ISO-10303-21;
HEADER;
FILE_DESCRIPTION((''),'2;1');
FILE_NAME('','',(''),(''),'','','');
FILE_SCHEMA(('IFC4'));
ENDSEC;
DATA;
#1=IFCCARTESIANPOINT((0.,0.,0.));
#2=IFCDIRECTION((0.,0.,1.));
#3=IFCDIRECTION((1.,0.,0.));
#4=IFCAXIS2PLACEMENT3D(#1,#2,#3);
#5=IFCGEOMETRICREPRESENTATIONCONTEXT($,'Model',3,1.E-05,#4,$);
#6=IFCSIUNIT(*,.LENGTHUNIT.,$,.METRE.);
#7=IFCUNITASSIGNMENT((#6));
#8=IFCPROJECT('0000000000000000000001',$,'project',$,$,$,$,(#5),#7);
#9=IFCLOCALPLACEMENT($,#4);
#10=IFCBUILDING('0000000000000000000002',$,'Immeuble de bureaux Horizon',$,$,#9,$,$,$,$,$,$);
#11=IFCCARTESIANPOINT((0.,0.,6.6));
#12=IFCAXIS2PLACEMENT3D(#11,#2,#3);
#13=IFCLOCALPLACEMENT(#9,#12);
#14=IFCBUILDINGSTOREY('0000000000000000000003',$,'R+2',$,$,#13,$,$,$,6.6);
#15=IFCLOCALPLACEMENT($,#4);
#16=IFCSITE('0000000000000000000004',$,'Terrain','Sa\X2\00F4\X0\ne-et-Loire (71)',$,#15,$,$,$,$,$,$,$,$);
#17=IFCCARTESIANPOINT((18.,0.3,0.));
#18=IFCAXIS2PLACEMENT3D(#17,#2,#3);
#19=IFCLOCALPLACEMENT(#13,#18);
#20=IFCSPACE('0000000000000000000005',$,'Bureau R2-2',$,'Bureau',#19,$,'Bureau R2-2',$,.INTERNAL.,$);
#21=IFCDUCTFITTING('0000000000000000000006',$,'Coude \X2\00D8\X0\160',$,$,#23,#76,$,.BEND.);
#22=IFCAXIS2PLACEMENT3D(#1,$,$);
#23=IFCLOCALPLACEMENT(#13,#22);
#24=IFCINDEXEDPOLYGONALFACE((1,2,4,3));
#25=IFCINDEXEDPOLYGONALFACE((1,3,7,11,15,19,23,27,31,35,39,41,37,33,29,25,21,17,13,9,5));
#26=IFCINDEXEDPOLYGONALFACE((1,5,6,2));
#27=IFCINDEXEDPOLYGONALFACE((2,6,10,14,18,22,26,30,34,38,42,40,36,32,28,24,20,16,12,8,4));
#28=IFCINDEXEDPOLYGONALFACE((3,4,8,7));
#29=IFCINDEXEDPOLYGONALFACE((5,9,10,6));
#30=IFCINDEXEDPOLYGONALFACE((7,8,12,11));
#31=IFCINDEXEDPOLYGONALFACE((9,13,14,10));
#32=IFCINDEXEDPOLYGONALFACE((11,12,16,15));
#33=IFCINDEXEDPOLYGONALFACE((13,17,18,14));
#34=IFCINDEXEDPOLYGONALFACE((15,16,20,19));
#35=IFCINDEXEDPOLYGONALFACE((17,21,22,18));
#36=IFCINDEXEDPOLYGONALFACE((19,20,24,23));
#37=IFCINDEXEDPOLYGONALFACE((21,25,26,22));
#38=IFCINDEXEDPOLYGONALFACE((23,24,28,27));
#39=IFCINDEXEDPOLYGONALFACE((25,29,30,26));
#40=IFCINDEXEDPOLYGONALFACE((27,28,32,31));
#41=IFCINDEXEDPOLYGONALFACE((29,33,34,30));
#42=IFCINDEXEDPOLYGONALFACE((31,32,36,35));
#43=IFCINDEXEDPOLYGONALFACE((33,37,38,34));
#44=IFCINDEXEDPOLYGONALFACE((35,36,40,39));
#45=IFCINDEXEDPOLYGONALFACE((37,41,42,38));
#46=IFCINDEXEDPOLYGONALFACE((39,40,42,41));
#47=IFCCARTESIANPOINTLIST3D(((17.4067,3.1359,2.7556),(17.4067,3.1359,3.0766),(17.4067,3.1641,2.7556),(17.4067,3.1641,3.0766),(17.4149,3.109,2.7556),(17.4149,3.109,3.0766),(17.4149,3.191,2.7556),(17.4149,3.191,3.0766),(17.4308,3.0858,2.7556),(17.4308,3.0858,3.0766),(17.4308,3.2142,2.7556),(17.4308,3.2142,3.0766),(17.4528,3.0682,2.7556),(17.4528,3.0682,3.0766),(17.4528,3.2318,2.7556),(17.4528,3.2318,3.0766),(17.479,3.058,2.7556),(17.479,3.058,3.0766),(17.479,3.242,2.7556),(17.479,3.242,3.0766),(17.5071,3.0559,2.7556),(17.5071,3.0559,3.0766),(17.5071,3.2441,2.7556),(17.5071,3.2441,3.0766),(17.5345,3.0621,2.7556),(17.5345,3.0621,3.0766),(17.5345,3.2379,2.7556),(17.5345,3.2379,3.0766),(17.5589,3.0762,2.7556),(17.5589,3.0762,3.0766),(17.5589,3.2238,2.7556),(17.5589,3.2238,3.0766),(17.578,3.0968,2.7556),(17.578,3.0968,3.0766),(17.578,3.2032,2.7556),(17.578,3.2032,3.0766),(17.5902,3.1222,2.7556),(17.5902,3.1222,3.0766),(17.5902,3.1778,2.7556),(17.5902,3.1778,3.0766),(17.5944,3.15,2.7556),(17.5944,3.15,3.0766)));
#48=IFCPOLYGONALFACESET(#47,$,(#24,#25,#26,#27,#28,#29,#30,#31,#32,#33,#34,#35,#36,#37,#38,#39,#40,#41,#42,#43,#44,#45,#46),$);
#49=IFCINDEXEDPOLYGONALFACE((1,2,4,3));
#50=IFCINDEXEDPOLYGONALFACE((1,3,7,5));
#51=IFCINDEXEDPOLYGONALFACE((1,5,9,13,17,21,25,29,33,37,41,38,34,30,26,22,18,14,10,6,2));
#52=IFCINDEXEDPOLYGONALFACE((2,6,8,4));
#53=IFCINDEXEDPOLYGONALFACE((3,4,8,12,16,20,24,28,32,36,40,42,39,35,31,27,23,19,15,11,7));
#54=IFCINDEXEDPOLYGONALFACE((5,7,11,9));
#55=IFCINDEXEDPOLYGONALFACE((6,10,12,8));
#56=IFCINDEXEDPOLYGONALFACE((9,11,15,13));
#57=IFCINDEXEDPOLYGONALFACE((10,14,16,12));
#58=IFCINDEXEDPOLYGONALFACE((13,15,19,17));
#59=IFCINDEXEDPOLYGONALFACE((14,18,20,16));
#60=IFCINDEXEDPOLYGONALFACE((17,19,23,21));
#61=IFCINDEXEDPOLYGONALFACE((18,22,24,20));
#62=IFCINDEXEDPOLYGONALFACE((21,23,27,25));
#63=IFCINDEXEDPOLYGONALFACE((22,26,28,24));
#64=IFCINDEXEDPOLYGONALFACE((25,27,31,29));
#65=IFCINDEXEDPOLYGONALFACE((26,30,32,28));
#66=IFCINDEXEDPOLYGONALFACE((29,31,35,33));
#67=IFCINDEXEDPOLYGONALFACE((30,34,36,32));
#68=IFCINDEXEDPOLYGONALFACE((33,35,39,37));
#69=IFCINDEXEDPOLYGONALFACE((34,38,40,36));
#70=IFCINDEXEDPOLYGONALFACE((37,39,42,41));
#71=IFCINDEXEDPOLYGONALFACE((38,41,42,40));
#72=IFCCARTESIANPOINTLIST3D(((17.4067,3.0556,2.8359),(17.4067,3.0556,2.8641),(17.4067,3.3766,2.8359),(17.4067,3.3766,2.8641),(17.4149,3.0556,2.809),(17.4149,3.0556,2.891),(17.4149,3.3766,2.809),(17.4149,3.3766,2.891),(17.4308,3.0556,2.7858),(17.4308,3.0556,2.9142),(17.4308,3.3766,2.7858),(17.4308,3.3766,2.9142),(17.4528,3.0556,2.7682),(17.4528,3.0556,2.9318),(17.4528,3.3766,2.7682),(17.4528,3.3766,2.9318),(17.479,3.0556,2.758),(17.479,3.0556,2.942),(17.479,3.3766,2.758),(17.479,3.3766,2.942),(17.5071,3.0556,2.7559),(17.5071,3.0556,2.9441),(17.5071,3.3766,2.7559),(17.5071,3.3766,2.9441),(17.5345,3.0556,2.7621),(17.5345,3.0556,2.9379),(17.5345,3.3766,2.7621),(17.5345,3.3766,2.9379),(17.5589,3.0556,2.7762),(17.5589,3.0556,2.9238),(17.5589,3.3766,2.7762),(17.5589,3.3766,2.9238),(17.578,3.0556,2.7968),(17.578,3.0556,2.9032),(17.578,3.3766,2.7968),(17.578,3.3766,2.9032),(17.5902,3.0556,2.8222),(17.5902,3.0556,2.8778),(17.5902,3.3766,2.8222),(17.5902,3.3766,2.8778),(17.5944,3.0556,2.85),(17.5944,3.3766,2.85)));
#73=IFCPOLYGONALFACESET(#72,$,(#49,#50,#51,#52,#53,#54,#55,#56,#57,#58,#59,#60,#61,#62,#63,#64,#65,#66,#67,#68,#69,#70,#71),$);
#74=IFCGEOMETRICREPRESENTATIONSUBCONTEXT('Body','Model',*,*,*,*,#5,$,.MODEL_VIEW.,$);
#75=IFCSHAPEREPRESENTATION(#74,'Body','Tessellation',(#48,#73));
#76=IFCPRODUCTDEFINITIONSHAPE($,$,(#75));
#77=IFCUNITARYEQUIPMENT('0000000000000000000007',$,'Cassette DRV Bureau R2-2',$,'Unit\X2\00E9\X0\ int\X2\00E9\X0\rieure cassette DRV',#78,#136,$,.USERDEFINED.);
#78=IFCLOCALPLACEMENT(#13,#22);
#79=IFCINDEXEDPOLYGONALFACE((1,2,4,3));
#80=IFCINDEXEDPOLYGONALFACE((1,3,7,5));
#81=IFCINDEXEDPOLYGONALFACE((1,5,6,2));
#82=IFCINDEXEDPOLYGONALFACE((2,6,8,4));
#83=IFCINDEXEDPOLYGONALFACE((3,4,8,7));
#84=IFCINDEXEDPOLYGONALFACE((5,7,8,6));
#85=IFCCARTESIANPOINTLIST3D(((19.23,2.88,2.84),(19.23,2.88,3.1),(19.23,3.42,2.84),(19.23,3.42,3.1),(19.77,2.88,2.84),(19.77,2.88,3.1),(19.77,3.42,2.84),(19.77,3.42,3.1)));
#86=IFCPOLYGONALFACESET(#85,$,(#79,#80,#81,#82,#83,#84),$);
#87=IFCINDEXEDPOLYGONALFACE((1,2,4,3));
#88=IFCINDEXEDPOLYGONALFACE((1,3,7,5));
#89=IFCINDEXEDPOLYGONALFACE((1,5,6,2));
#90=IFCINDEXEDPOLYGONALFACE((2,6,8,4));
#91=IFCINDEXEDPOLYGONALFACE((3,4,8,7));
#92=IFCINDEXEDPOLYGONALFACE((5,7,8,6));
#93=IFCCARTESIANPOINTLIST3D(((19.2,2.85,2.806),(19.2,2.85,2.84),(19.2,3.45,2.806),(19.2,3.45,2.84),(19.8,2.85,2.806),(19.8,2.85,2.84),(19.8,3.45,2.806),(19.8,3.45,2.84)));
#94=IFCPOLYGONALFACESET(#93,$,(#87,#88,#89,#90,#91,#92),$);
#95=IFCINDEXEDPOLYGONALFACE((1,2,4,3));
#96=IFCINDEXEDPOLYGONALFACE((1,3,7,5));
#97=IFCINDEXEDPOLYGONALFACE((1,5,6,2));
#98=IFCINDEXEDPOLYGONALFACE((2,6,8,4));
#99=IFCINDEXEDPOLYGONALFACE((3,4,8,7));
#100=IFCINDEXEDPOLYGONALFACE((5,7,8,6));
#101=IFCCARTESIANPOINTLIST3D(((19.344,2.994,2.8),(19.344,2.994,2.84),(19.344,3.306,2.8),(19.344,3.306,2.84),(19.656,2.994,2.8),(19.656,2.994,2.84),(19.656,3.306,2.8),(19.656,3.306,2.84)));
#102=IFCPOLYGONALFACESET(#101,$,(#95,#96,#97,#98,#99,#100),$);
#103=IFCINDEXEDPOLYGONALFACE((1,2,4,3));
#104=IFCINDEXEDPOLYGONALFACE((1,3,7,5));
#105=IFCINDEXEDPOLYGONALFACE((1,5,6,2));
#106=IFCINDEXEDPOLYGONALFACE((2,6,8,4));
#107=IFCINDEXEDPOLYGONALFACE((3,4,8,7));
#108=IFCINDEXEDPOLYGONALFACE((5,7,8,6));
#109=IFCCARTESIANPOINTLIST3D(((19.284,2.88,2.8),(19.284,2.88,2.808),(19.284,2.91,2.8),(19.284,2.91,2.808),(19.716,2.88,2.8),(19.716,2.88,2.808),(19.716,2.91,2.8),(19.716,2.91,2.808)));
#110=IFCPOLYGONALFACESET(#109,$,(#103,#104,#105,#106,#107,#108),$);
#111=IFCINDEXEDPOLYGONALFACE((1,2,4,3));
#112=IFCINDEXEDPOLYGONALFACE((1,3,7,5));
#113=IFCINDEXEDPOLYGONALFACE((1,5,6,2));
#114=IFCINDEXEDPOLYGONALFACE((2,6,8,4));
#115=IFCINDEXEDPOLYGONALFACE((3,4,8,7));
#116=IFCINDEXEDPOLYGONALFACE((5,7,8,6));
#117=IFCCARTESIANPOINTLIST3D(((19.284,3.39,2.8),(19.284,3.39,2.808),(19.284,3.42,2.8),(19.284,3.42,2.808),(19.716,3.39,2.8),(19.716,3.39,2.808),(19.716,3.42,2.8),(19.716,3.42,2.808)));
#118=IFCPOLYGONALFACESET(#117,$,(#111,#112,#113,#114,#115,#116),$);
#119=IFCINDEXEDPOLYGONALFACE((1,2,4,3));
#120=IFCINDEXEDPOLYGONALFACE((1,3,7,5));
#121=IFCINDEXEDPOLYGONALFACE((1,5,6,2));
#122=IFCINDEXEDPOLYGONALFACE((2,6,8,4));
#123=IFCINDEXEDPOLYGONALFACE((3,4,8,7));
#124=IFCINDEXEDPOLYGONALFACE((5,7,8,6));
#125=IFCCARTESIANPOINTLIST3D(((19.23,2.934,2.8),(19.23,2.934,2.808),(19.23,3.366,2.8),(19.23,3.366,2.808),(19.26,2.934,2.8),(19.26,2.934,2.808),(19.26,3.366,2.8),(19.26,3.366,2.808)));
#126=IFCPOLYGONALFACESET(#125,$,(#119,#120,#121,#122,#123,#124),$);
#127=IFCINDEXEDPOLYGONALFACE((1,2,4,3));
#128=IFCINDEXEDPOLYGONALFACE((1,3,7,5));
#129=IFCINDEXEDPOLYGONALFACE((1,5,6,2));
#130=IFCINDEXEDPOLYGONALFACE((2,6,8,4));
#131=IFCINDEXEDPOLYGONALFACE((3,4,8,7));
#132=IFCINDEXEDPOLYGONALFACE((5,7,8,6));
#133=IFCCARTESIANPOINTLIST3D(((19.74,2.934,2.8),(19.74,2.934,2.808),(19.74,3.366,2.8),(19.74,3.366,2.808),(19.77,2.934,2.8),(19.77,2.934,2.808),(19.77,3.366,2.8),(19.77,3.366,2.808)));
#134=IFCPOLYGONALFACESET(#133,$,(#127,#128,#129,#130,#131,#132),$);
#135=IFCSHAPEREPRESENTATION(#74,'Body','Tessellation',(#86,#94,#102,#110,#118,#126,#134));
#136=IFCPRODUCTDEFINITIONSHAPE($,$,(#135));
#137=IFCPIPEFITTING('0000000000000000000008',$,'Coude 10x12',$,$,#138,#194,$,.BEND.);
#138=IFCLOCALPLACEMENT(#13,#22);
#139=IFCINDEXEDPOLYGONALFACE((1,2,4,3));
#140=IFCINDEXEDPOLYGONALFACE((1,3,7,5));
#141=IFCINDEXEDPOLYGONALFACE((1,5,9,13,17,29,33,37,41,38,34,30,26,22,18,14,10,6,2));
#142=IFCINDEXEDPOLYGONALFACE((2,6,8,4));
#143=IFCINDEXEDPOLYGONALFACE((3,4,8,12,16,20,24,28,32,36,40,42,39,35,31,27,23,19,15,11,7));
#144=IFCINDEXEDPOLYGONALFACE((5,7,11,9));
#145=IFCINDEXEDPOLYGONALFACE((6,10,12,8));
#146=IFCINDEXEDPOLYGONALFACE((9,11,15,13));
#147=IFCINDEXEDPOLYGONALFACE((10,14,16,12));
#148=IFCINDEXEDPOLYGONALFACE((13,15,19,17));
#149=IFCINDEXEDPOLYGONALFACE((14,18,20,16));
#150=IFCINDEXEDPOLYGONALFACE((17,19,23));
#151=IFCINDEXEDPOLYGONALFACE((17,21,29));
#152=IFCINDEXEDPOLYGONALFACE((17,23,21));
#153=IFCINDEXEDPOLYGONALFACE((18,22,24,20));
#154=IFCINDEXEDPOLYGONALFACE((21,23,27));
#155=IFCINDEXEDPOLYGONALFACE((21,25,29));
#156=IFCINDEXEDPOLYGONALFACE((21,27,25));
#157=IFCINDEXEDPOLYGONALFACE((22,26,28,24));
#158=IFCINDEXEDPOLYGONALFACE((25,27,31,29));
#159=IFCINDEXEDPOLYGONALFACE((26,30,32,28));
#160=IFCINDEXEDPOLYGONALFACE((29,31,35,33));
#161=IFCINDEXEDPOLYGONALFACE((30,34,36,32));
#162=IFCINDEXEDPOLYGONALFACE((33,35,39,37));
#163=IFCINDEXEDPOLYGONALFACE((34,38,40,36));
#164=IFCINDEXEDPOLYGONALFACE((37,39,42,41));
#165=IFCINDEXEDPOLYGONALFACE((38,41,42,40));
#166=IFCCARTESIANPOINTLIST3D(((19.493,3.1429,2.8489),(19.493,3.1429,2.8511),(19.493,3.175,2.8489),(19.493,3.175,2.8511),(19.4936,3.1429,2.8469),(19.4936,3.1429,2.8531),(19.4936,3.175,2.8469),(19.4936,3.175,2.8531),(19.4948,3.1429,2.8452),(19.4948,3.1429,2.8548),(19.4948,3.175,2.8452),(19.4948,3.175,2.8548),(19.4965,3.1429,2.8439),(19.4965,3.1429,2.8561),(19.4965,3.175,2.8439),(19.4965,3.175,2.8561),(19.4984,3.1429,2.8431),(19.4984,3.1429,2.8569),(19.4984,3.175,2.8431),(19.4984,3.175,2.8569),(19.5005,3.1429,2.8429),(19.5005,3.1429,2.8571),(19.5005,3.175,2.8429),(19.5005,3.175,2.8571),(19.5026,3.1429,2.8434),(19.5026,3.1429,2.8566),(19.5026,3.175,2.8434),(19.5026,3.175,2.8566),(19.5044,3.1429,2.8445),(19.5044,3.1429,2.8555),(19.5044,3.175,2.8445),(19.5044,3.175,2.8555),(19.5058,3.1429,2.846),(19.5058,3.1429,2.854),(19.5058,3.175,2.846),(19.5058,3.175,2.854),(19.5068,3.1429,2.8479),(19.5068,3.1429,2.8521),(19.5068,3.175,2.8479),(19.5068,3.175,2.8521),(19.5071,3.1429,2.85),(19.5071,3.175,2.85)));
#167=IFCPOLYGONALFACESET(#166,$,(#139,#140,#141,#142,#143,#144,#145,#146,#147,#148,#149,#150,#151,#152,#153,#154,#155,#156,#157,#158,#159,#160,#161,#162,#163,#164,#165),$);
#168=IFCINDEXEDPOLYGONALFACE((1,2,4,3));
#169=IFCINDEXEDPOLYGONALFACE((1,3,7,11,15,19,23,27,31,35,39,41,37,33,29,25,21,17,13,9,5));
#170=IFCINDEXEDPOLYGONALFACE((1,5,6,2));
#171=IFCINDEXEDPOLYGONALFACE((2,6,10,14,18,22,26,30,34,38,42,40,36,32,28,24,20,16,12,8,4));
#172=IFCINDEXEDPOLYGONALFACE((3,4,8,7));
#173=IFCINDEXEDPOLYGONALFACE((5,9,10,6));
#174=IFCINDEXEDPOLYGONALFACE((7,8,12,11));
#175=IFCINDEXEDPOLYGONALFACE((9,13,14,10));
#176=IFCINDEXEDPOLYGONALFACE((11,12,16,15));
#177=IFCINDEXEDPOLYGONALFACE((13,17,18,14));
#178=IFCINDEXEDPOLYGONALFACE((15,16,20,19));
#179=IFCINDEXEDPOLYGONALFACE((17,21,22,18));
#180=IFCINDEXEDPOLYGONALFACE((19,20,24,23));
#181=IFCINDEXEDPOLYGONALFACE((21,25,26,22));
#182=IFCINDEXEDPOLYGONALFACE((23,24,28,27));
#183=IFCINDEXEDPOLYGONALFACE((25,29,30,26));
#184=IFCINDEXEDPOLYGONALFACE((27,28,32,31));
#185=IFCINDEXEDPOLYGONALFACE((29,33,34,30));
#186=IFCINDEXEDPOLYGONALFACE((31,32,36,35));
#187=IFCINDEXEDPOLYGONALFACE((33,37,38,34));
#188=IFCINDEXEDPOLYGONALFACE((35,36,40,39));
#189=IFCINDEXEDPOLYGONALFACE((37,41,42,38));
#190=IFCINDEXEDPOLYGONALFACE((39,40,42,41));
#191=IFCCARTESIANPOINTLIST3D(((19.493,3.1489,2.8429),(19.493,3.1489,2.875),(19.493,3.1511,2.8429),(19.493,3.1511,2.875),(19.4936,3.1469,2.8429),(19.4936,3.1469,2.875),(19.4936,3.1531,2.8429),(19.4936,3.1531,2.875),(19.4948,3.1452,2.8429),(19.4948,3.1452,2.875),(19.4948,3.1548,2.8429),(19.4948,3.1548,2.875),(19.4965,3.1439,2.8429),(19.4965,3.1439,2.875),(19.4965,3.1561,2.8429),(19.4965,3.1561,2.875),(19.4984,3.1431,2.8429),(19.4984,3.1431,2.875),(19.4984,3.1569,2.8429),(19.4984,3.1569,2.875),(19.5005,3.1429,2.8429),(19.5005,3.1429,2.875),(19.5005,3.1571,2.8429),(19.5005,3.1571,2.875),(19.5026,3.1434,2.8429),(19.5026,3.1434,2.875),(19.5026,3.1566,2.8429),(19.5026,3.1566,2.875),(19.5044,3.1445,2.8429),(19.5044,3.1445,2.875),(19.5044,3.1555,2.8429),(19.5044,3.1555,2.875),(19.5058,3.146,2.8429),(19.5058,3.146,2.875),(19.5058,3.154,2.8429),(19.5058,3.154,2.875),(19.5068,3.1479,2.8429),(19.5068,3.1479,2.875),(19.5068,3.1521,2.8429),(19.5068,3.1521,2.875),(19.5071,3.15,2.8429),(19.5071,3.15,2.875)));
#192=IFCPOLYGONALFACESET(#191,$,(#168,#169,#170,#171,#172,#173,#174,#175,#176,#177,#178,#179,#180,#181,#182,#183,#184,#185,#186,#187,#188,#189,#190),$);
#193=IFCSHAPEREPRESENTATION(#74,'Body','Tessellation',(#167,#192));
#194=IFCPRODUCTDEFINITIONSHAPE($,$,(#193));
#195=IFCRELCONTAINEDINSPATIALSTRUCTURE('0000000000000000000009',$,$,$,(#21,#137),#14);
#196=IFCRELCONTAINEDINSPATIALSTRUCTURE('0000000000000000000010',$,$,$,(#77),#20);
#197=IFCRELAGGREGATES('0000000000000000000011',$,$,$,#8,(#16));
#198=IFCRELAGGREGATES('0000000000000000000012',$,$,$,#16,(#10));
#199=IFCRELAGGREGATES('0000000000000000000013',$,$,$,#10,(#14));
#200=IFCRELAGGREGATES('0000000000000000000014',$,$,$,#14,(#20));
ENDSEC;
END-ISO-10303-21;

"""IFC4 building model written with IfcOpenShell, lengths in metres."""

from ifc_helpers import new_model, si_unit, frame, frame_2d, origin_with_axes, place, context, subcontext, project, spatial, rectangle, circle, extrude, element, save


model = new_model("IFC4")

# Units and contexts
model_context = context("Model", 3, precision=1e-05, world=origin_with_axes())
body_context = subcontext(model_context, "Body", "Model", "MODEL_VIEW")
ifc_project = project(units=[si_unit("LENGTHUNIT", "METRE")], contexts=[model_context])

# Site, building, storey
site_placement = place(None, origin_with_axes())
site = spatial("IfcSite", under=ifc_project, at=site_placement, Name="Terrain", Description="Saône-et-Loire (71)")
building_placement = place(None, origin_with_axes())
building = spatial("IfcBuilding", under=site, at=building_placement, Name="Immeuble de bureaux Horizon")
storey_placement = place(building_placement, frame((0.0, 0.0, 6.6), z_axis=(0.0, 0.0, 1.0), x_axis=(1.0, 0.0, 0.0)))
storey = spatial("IfcBuildingStorey", under=building, at=storey_placement, Name="R+2", Elevation=6.6)

# Duct fitting
duct_fitting_1_placement = place(storey_placement, frame((17.5, 3.15, 2.85), z_axis=(0.0, 0.0, 1.0), x_axis=(1.0, 0.0, 0.0)))
element("IfcDuctFitting", 1, at=duct_fitting_1_placement, inside=storey, Name="Coude Ø160", PredefinedType="BEND", context=body_context, shape_type="SweptSolid", body=[
    extrude(circle(Radius=0.0944), frame((0.0, 0.0, -0.0944), z_axis=(0.0, 0.0, 1.0), x_axis=(1.0, 0.0, 0.0)), (0.0, 0.0, 1.0), 0.321),
    extrude(circle(Radius=0.0944), frame((0.0, -0.0944, 0.0), z_axis=(0.0, 1.0, 0.0), x_axis=(1.0, 0.0, 0.0)), (0.0, 0.0, 1.0), 0.321),
])

# Shared definitions
space_1_placement = place(storey_placement, frame((18.0, 0.3, 0.0), z_axis=(0.0, 0.0, 1.0), x_axis=(1.0, 0.0, 0.0)))
space_1 = spatial("IfcSpace", under=storey, at=space_1_placement, Name="Bureau R2-2", ObjectType="Bureau", LongName="Bureau R2-2", PredefinedType="INTERNAL")

# Unitary equipment
unitary_equipment_1_placement = place(space_1_placement, frame((1.2, 2.55, 2.8), z_axis=(0.0, 0.0, 1.0), x_axis=(1.0, 0.0, 0.0)))
element("IfcUnitaryEquipment", 2, at=unitary_equipment_1_placement, inside=space_1, Name="Cassette DRV Bureau R2-2", ObjectType="Unité intérieure cassette DRV", PredefinedType="USERDEFINED", context=body_context, shape_type="SweptSolid", body=[
    extrude(rectangle(XDim=0.54, YDim=0.54, at=frame_2d((0.27, 0.27))), frame((0.03, 0.03, 0.04), z_axis=(0.0, 0.0, 1.0), x_axis=(1.0, 0.0, 0.0)), (0.0, 0.0, 1.0), 0.26),
    extrude(rectangle(XDim=0.6, YDim=0.6, at=frame_2d((0.3, 0.3))), frame((0.0, 0.0, 0.006), z_axis=(0.0, 0.0, 1.0), x_axis=(1.0, 0.0, 0.0)), (0.0, 0.0, 1.0), 0.034),
    extrude(rectangle(XDim=0.312, YDim=0.312, at=frame_2d((0.156, 0.156))), frame((0.144, 0.144, 0.0), z_axis=(0.0, 0.0, 1.0), x_axis=(1.0, 0.0, 0.0)), (0.0, 0.0, 1.0), 0.04),
    extrude(rectangle(XDim=0.432, YDim=0.03, at=frame_2d((0.216, 0.015))), frame((0.084, 0.03, 0.0), z_axis=(0.0, 0.0, 1.0), x_axis=(1.0, 0.0, 0.0)), (0.0, 0.0, 1.0), 0.008),
    extrude(rectangle(XDim=0.432, YDim=0.03, at=frame_2d((0.216, 0.015))), frame((0.084, 0.54, 0.0), z_axis=(0.0, 0.0, 1.0), x_axis=(1.0, 0.0, 0.0)), (0.0, 0.0, 1.0), 0.008),
    extrude(rectangle(XDim=0.03, YDim=0.432, at=frame_2d((0.015, 0.216))), frame((0.03, 0.084, 0.0), z_axis=(0.0, 0.0, 1.0), x_axis=(1.0, 0.0, 0.0)), (0.0, 0.0, 1.0), 0.008),
    extrude(rectangle(XDim=0.03, YDim=0.432, at=frame_2d((0.015, 0.216))), frame((0.54, 0.084, 0.0), z_axis=(0.0, 0.0, 1.0), x_axis=(1.0, 0.0, 0.0)), (0.0, 0.0, 1.0), 0.008),
])

# Pipe fitting
pipe_fitting_1_placement = place(storey_placement, frame((19.5, 3.15, 2.85), z_axis=(0.0, 0.0, 1.0), x_axis=(1.0, 0.0, 0.0)))
element("IfcPipeFitting", 3, at=pipe_fitting_1_placement, inside=storey, Name="Coude 10x12", PredefinedType="BEND", context=body_context, shape_type="SweptSolid", body=[
    extrude(circle(Radius=0.0071), frame((0.0, -0.0071, 0.0), z_axis=(0.0, 1.0, 0.0), x_axis=(1.0, 0.0, 0.0)), (0.0, 0.0, 1.0), 0.0321),
    extrude(circle(Radius=0.0071), frame((0.0, 0.0, -0.0071), z_axis=(0.0, 0.0, 1.0), x_axis=(1.0, 0.0, 0.0)), (0.0, 0.0, 1.0), 0.0321),
])

save(model, "model.ifc")
